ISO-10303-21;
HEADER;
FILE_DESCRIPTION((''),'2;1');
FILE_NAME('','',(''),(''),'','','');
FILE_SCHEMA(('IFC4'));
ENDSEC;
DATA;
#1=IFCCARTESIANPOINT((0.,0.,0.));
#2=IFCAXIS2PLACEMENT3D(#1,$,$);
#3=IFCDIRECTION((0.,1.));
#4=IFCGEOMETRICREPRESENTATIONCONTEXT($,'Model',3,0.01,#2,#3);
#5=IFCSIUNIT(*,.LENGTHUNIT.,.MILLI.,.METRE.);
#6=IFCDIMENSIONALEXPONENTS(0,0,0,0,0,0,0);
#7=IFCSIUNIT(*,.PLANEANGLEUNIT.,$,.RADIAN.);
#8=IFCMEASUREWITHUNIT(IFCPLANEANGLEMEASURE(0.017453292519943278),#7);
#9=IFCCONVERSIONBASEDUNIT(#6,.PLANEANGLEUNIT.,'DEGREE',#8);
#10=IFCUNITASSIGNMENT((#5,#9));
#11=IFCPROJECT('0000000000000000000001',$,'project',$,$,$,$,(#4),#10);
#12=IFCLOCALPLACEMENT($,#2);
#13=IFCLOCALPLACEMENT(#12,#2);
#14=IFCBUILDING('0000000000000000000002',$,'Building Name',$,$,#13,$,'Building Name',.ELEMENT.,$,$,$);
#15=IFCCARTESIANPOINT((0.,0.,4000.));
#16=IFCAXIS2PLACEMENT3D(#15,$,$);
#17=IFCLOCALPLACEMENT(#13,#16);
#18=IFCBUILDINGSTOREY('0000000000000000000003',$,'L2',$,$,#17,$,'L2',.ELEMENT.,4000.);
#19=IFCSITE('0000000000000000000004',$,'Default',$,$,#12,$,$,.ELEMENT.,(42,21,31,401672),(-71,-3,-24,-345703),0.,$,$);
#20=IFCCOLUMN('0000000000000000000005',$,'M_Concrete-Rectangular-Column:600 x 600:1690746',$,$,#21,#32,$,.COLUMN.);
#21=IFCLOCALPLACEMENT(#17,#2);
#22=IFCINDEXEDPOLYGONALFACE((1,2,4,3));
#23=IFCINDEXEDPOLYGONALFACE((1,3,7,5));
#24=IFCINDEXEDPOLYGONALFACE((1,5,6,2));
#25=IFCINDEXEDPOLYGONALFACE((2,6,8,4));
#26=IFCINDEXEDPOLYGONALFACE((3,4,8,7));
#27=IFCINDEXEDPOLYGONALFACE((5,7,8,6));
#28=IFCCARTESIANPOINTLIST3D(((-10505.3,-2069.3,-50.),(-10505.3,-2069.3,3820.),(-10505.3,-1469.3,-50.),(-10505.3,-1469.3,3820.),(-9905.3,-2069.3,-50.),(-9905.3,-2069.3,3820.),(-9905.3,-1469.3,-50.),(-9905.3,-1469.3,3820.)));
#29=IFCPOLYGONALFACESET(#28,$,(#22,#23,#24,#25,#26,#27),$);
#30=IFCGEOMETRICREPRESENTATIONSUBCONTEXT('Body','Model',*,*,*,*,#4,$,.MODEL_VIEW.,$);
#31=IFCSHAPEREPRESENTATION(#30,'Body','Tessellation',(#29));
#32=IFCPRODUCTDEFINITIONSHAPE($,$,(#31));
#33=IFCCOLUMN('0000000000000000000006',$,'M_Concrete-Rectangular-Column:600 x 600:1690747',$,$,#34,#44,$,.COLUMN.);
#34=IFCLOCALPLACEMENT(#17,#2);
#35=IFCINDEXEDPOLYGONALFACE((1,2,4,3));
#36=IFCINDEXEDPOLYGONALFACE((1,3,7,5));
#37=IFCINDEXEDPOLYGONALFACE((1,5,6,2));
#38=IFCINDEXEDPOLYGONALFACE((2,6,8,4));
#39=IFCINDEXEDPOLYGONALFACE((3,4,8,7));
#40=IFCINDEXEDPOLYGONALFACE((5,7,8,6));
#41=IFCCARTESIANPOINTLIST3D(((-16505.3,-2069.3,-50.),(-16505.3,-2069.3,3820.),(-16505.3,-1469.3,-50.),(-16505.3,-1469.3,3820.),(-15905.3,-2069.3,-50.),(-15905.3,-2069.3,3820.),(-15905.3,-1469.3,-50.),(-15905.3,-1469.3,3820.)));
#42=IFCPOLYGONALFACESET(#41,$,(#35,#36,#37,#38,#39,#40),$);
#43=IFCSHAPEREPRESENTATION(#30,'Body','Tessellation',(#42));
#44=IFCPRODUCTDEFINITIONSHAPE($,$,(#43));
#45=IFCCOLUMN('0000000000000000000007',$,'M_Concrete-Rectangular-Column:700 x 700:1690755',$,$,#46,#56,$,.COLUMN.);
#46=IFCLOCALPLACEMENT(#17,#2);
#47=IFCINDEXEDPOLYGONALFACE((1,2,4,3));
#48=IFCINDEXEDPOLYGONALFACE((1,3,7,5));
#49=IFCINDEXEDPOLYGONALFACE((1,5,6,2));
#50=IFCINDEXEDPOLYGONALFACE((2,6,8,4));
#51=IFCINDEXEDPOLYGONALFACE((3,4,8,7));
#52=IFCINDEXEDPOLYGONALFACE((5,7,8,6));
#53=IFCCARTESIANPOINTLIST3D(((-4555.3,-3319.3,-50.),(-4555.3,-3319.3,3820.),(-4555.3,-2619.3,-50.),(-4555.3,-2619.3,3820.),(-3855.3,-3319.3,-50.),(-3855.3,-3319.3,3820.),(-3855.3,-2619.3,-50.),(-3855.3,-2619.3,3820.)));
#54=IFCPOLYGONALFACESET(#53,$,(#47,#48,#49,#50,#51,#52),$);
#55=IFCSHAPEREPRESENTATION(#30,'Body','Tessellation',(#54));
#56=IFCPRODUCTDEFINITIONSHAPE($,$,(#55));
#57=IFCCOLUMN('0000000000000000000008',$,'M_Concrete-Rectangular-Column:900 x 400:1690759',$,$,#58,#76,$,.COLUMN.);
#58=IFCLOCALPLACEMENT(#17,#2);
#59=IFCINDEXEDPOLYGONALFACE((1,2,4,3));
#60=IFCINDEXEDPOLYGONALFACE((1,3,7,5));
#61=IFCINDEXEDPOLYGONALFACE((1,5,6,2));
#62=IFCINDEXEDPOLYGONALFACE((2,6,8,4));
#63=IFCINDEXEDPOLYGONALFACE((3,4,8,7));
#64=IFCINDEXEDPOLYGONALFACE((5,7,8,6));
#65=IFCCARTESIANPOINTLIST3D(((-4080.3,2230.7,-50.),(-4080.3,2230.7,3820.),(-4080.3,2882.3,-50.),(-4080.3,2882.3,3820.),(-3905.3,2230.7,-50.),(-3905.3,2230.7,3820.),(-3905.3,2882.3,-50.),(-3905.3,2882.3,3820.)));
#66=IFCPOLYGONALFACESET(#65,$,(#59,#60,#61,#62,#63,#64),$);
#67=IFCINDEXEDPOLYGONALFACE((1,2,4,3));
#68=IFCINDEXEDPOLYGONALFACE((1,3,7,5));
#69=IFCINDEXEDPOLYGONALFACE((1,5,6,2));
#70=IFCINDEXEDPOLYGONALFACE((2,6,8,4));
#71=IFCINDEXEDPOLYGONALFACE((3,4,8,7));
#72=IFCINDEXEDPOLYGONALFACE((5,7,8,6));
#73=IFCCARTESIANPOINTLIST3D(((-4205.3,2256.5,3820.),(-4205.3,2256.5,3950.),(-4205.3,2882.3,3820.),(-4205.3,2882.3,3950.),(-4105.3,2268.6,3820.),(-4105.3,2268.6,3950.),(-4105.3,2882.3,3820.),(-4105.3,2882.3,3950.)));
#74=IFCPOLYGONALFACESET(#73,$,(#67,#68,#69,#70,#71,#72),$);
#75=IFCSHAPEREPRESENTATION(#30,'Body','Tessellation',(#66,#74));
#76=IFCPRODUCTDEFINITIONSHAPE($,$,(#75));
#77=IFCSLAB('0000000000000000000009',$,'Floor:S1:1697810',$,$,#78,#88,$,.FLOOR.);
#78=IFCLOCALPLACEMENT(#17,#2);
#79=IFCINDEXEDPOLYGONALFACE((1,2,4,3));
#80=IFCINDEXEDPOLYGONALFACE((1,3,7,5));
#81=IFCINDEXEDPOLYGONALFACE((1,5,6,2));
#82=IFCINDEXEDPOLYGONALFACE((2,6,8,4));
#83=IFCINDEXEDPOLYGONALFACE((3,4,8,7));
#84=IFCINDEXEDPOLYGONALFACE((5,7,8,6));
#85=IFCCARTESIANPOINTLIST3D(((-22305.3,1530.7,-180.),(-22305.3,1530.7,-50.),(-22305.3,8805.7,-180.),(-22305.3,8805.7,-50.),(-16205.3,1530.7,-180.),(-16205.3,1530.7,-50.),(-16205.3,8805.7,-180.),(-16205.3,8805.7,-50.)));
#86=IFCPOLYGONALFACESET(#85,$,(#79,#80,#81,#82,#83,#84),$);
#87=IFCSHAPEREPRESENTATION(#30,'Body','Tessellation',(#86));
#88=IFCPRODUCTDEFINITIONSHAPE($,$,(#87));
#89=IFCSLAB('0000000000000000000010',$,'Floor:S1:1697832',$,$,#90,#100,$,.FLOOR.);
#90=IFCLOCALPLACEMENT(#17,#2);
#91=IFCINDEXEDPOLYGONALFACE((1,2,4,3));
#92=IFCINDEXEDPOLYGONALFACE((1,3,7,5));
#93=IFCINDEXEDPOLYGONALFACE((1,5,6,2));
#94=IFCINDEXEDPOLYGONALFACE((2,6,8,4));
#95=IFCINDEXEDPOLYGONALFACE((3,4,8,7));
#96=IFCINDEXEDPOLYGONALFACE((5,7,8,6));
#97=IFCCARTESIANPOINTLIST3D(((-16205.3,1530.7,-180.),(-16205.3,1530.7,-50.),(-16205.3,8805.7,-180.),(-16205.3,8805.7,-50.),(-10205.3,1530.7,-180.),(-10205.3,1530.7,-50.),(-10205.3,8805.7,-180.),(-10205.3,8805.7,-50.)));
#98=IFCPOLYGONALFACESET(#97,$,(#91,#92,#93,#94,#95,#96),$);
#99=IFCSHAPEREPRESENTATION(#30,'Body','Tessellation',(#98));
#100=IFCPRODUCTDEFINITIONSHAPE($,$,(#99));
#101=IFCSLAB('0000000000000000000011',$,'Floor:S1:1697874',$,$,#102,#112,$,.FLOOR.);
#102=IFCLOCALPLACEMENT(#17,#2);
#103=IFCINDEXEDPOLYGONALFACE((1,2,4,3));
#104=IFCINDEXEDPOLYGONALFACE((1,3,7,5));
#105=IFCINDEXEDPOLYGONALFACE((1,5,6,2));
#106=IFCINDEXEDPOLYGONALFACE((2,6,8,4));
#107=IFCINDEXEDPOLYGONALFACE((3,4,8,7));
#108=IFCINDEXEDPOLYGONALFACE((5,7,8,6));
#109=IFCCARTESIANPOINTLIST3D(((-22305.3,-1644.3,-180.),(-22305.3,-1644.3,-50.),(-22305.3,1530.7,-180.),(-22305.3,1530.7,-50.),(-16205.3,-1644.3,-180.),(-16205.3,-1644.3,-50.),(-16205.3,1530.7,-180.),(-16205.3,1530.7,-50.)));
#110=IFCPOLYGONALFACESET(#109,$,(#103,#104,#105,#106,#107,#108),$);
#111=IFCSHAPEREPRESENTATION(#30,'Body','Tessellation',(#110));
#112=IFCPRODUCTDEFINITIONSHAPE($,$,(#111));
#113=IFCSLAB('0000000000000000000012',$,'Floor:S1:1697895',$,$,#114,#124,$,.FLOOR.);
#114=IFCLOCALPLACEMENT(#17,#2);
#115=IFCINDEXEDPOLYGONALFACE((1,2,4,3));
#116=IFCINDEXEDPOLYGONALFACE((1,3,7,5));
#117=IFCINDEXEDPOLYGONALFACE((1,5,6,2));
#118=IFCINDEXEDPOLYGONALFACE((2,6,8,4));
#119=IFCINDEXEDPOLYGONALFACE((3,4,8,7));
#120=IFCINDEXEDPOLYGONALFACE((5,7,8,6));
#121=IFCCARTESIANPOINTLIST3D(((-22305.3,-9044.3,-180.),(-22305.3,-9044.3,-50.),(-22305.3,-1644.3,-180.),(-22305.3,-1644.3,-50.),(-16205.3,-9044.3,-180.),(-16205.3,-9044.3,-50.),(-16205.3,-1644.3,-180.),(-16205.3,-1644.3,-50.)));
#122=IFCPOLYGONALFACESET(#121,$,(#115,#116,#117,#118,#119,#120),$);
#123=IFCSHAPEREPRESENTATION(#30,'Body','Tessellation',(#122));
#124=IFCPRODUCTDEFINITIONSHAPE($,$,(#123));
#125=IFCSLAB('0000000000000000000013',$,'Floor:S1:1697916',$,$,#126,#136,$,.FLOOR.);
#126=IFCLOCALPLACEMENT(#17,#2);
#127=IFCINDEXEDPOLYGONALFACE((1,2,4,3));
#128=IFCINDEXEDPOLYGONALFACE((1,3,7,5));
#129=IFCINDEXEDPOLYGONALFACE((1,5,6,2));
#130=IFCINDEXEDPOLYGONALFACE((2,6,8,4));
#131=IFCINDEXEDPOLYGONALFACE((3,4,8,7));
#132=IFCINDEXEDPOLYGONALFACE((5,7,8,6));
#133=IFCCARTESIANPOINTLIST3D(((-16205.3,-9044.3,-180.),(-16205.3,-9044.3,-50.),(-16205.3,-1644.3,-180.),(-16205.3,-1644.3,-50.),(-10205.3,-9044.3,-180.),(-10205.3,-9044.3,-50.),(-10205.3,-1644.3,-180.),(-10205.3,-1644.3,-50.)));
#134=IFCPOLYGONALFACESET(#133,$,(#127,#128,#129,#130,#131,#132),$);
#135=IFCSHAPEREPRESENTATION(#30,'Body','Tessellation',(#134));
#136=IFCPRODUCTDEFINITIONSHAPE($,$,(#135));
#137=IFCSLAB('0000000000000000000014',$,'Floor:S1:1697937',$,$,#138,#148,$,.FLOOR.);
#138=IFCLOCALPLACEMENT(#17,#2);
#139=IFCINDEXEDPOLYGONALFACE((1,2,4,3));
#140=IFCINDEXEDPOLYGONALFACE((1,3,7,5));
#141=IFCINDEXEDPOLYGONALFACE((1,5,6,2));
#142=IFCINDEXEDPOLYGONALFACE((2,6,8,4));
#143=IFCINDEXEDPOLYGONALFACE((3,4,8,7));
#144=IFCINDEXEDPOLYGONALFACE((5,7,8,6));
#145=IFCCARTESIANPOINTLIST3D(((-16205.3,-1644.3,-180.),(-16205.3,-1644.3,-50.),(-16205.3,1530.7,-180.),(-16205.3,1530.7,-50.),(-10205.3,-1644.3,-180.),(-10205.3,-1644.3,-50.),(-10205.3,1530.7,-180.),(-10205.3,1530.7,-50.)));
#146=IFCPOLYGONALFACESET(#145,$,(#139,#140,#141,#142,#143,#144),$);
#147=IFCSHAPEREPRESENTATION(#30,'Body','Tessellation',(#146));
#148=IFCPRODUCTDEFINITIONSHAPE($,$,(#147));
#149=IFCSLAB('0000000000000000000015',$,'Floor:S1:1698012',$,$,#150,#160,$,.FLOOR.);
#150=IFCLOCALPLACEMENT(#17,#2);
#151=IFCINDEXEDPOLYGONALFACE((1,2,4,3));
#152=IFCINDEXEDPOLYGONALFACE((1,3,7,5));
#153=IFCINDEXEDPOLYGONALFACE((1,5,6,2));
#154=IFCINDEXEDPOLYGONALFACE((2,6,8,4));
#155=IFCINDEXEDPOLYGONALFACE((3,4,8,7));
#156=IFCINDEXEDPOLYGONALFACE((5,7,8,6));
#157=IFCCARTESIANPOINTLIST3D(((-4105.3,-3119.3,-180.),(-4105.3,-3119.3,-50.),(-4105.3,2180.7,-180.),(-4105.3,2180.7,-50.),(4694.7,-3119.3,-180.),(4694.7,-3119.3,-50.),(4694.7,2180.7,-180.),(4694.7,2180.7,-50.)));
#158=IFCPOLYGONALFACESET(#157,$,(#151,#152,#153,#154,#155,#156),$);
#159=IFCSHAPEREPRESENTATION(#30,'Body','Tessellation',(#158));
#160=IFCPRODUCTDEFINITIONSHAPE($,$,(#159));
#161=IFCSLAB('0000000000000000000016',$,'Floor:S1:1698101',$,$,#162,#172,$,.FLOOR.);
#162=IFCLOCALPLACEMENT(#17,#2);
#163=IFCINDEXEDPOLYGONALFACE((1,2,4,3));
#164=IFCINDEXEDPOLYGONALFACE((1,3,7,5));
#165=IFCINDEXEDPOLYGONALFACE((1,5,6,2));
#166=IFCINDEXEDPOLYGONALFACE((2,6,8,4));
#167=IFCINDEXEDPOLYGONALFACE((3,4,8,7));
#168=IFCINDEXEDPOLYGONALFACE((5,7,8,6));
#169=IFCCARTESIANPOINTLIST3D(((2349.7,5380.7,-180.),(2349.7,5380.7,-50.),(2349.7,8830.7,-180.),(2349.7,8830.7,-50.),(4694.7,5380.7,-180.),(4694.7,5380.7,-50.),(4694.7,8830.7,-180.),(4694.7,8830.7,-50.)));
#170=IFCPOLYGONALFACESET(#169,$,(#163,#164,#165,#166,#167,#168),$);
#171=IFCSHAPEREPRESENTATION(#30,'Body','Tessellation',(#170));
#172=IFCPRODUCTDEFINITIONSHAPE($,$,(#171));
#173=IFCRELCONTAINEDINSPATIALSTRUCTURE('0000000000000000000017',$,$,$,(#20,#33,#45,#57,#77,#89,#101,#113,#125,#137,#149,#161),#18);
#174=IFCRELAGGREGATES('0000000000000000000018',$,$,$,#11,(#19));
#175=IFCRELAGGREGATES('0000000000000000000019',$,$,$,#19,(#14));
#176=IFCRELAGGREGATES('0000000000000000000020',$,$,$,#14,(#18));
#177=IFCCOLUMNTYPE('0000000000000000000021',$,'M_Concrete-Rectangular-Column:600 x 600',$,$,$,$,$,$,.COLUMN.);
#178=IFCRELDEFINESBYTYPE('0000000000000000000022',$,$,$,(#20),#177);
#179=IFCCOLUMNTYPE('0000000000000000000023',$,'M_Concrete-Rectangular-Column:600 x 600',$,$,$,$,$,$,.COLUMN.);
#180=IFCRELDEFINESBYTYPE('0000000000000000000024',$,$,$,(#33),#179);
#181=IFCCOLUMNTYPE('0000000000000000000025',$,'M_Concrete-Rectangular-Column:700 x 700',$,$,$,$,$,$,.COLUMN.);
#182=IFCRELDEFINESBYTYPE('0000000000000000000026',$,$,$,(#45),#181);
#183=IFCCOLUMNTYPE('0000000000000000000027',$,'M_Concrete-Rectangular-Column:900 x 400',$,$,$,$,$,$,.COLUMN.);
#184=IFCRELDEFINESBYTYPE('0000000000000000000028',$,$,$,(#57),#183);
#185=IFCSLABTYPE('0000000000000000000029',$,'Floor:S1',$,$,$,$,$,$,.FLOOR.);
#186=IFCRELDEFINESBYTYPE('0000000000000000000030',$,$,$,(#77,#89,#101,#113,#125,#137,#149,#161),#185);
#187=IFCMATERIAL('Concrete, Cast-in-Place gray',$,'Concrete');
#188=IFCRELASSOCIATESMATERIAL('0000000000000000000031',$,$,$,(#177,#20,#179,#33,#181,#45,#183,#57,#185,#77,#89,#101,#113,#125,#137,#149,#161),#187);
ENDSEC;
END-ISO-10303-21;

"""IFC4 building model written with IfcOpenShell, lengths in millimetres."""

from ifc_helpers import new_model, entity, si_unit, converted_unit, direction, frame, origin, place, context, subcontext, project, spatial, indexed_curve, outline, extrude, source, transform, mapped, material, type_object, type_shapes, element, save


model = new_model("IFC4")

# Units and contexts
model_context = context("Model", 3, precision=0.01, world=origin(), true_north=direction((0.0, 1.0)))
body_context = subcontext(model_context, "Body", "Model", "MODEL_VIEW")
ifc_project = project(units=[si_unit("LENGTHUNIT", "METRE", prefix="MILLI"), converted_unit("PLANEANGLEUNIT", "DEGREE", entity("IfcPlaneAngleMeasure", 0.017453292519943278), si_unit("PLANEANGLEUNIT", "RADIAN"), dimensions=[0, 0, 0, 0, 0, 0, 0])], contexts=[model_context])

# Site, building, storey
site_placement = place(None, origin())
site = spatial("IfcSite", under=ifc_project, at=site_placement, Name="Default", CompositionType="ELEMENT", RefLatitude=(42, 21, 31, 401672), RefLongitude=(-71, -3, -24, -345703), RefElevation=0.0)
building_placement = place(site_placement, origin())
building = spatial("IfcBuilding", under=site, at=building_placement, Name="Building Name", LongName="Building Name", CompositionType="ELEMENT")
storey_placement = place(building_placement, frame((0.0, 0.0, 4000.0)))
storey = spatial("IfcBuildingStorey", under=building, at=storey_placement, Name="L2", LongName="L2", CompositionType="ELEMENT", Elevation=4000.0)

# Columns
ifc_material = material(Name="Concrete, Cast-in-Place gray", Category="Concrete")
column_type_1 = type_object("IfcColumnType", Name="M_Concrete-Rectangular-Column:600 x 600", PredefinedType="COLUMN", material=ifc_material)
shared_shape_1 = source(origin(), body_context, "Body", "SweptSolid", [
    extrude(outline(indexed_curve([(-300.0, -300.0), (300.0, -300.0), (300.0, 300.0), (-300.0, 300.0), (-300.0, -300.0)], self_intersect=False)), frame((-10205.3, -1769.3, 3950.0), z_axis=(0.0, 0.0, 1.0), x_axis=(-1.0, 0.0, 0.0)), (0.0, 0.0, 1.0), 3870.0),
])
type_shapes(column_type_1, [shared_shape_1])
column_1_placement = place(storey_placement, frame((0.0, 0.0, -4000.0)))
element("IfcColumn", 1, at=column_1_placement, inside=storey, type_object=column_type_1, material=ifc_material, Name="M_Concrete-Rectangular-Column:600 x 600:1690746", PredefinedType="COLUMN", context=body_context, shape_type="MappedRepresentation", body=[
    mapped(shared_shape_1, transform((0.0, 0.0, 0.0), scale=1.0)),
])
column_type_2 = type_object("IfcColumnType", Name="M_Concrete-Rectangular-Column:600 x 600", PredefinedType="COLUMN", material=ifc_material)
shared_shape_2 = source(origin(), body_context, "Body", "SweptSolid", [
    extrude(outline(indexed_curve([(-300.0, -300.0), (300.0, -300.0), (300.0, 300.0), (-300.0, 300.0), (-300.0, -300.0)], self_intersect=False)), frame((-16205.3, -1769.3, 3950.0), z_axis=(0.0, 0.0, 1.0), x_axis=(-1.0, 0.0, 0.0)), (0.0, 0.0, 1.0), 3870.0),
])
type_shapes(column_type_2, [shared_shape_2])
column_2_placement = place(storey_placement, frame((0.0, 0.0, -4000.0)))
element("IfcColumn", 2, at=column_2_placement, inside=storey, type_object=column_type_2, material=ifc_material, Name="M_Concrete-Rectangular-Column:600 x 600:1690747", PredefinedType="COLUMN", context=body_context, shape_type="MappedRepresentation", body=[
    mapped(shared_shape_2, transform((0.0, 0.0, 0.0), scale=1.0)),
])
column_type_3 = type_object("IfcColumnType", Name="M_Concrete-Rectangular-Column:700 x 700", PredefinedType="COLUMN", material=ifc_material)
shared_shape_3 = source(origin(), body_context, "Body", "SweptSolid", [
    extrude(outline(indexed_curve([(-350.0, -350.0), (350.0, -350.0), (350.0, 350.0), (-350.0, 350.0), (-350.0, -350.0)], self_intersect=False)), frame((-4205.3, -2969.3, 3950.0), z_axis=(0.0, 0.0, 1.0), x_axis=(-1.0, 0.0, 0.0)), (0.0, 0.0, 1.0), 3870.0),
])
type_shapes(column_type_3, [shared_shape_3])
column_3_placement = place(storey_placement, frame((0.0, 0.0, -4000.0)))
element("IfcColumn", 3, at=column_3_placement, inside=storey, type_object=column_type_3, material=ifc_material, Name="M_Concrete-Rectangular-Column:700 x 700:1690755", PredefinedType="COLUMN", context=body_context, shape_type="MappedRepresentation", body=[
    mapped(shared_shape_3, transform((0.0, 0.0, 0.0), scale=1.0)),
])
column_type_4 = type_object("IfcColumnType", Name="M_Concrete-Rectangular-Column:900 x 400", PredefinedType="COLUMN", material=ifc_material)
shared_shape_4 = source(origin(), body_context, "Body", "SweptSolid", [
    extrude(outline(indexed_curve([(-87.5, -325.8), (87.5, -325.8), (87.5, 325.8), (-87.5, 325.8), (-87.5, -325.8)], self_intersect=False)), frame((-3992.8, 2556.5, 3950.0), z_axis=(0.0, 0.0, 1.0), x_axis=(-1.0, 0.0, 0.0)), (0.0, 0.0, 1.0), 3870.0),
    extrude(outline(indexed_curve([(-309.9, -50.0), (315.9, -50.0), (303.8, 50.0), (-309.9, 50.0), (-309.9, -50.0)], self_intersect=False)), frame((-4155.3, 2572.4, 7820.0), z_axis=(0.0, 0.0, 1.0), x_axis=(0.0, -1.0, 0.0)), (0.0, 0.0, 1.0), 130.0),
])
type_shapes(column_type_4, [shared_shape_4])
column_4_placement = place(storey_placement, frame((0.0, 0.0, -4000.0)))
element("IfcColumn", 4, at=column_4_placement, inside=storey, type_object=column_type_4, material=ifc_material, Name="M_Concrete-Rectangular-Column:900 x 400:1690759", PredefinedType="COLUMN", context=body_context, shape_type="MappedRepresentation", body=[
    mapped(shared_shape_4, transform((0.0, 0.0, 0.0), scale=1.0)),
])

# Slabs
slab_type = type_object("IfcSlabType", Name="Floor:S1", PredefinedType="FLOOR", material=ifc_material)
slab_1_placement = place(storey_placement, origin())
element("IfcSlab", 5, at=slab_1_placement, inside=storey, type_object=slab_type, material=ifc_material, Name="Floor:S1:1697810", PredefinedType="FLOOR", context=body_context, shape_type="SweptSolid", body=[
    extrude(outline(indexed_curve([(-3637.5, -3050.0), (3637.5, -3050.0), (3637.5, 3050.0), (-3637.5, 3050.0), (-3637.5, -3050.0)], self_intersect=False)), frame((-19255.3, 5168.2, -50.0), z_axis=(0.0, 0.0, -1.0), x_axis=(0.0, 1.0, 0.0)), (0.0, 0.0, 1.0), 130.0),
])
slab_2_placement = place(storey_placement, origin())
element("IfcSlab", 6, at=slab_2_placement, inside=storey, type_object=slab_type, material=ifc_material, Name="Floor:S1:1697832", PredefinedType="FLOOR", context=body_context, shape_type="SweptSolid", body=[
    extrude(outline(indexed_curve([(-3637.5, -3000.0), (3637.5, -3000.0), (3637.5, 3000.0), (-3637.5, 3000.0), (-3637.5, -3000.0)], self_intersect=False)), frame((-13205.3, 5168.2, -50.0), z_axis=(0.0, 0.0, -1.0), x_axis=(0.0, 1.0, 0.0)), (0.0, 0.0, 1.0), 130.0),
])
slab_3_placement = place(storey_placement, origin())
element("IfcSlab", 7, at=slab_3_placement, inside=storey, type_object=slab_type, material=ifc_material, Name="Floor:S1:1697874", PredefinedType="FLOOR", context=body_context, shape_type="SweptSolid", body=[
    extrude(outline(indexed_curve([(-1587.5, -3050.0), (1587.5, -3050.0), (1587.5, 3050.0), (-1587.5, 3050.0), (-1587.5, -3050.0)], self_intersect=False)), frame((-19255.3, -56.8, -50.0), z_axis=(0.0, 0.0, -1.0), x_axis=(0.0, 1.0, 0.0)), (0.0, 0.0, 1.0), 130.0),
])
slab_4_placement = place(storey_placement, origin())
element("IfcSlab", 8, at=slab_4_placement, inside=storey, type_object=slab_type, material=ifc_material, Name="Floor:S1:1697895", PredefinedType="FLOOR", context=body_context, shape_type="SweptSolid", body=[
    extrude(outline(indexed_curve([(-3700.0, -3050.0), (3700.0, -3050.0), (3700.0, 3050.0), (-3700.0, 3050.0), (-3700.0, -3050.0)], self_intersect=False)), frame((-19255.3, -5344.3, -50.0), z_axis=(0.0, 0.0, -1.0), x_axis=(0.0, 1.0, 0.0)), (0.0, 0.0, 1.0), 130.0),
])
slab_5_placement = place(storey_placement, origin())
element("IfcSlab", 9, at=slab_5_placement, inside=storey, type_object=slab_type, material=ifc_material, Name="Floor:S1:1697916", PredefinedType="FLOOR", context=body_context, shape_type="SweptSolid", body=[
    extrude(outline(indexed_curve([(-3700.0, -3000.0), (3700.0, -3000.0), (3700.0, 3000.0), (-3700.0, 3000.0), (-3700.0, -3000.0)], self_intersect=False)), frame((-13205.3, -5344.3, -50.0), z_axis=(0.0, 0.0, -1.0), x_axis=(0.0, 1.0, 0.0)), (0.0, 0.0, 1.0), 130.0),
])
slab_6_placement = place(storey_placement, origin())
element("IfcSlab", 10, at=slab_6_placement, inside=storey, type_object=slab_type, material=ifc_material, Name="Floor:S1:1697937", PredefinedType="FLOOR", context=body_context, shape_type="SweptSolid", body=[
    extrude(outline(indexed_curve([(-1587.5, -3000.0), (1587.5, -3000.0), (1587.5, 3000.0), (-1587.5, 3000.0), (-1587.5, -3000.0)], self_intersect=False)), frame((-13205.3, -56.8, -50.0), z_axis=(0.0, 0.0, -1.0), x_axis=(0.0, 1.0, 0.0)), (0.0, 0.0, 1.0), 130.0),
])
slab_7_placement = place(storey_placement, origin())
element("IfcSlab", 11, at=slab_7_placement, inside=storey, type_object=slab_type, material=ifc_material, Name="Floor:S1:1698012", PredefinedType="FLOOR", context=body_context, shape_type="SweptSolid", body=[
    extrude(outline(indexed_curve([(-2650.0, -4400.0), (2650.0, -4400.0), (2650.0, 4400.0), (-2650.0, 4400.0), (-2650.0, -4400.0)], self_intersect=False)), frame((294.7, -469.3, -50.0), z_axis=(0.0, 0.0, -1.0), x_axis=(0.0, 1.0, 0.0)), (0.0, 0.0, 1.0), 130.0),
])
slab_8_placement = place(storey_placement, origin())
element("IfcSlab", 12, at=slab_8_placement, inside=storey, type_object=slab_type, material=ifc_material, Name="Floor:S1:1698101", PredefinedType="FLOOR", context=body_context, shape_type="SweptSolid", body=[
    extrude(outline(indexed_curve([(-1725.0, -1172.5), (1725.0, -1172.5), (1725.0, 1172.5), (-1725.0, 1172.5), (-1725.0, -1172.5)], self_intersect=False)), frame((3522.2, 7105.7, -50.0), z_axis=(0.0, 0.0, -1.0), x_axis=(0.0, 1.0, 0.0)), (0.0, 0.0, 1.0), 130.0),
])

save(model, "model.ifc")
